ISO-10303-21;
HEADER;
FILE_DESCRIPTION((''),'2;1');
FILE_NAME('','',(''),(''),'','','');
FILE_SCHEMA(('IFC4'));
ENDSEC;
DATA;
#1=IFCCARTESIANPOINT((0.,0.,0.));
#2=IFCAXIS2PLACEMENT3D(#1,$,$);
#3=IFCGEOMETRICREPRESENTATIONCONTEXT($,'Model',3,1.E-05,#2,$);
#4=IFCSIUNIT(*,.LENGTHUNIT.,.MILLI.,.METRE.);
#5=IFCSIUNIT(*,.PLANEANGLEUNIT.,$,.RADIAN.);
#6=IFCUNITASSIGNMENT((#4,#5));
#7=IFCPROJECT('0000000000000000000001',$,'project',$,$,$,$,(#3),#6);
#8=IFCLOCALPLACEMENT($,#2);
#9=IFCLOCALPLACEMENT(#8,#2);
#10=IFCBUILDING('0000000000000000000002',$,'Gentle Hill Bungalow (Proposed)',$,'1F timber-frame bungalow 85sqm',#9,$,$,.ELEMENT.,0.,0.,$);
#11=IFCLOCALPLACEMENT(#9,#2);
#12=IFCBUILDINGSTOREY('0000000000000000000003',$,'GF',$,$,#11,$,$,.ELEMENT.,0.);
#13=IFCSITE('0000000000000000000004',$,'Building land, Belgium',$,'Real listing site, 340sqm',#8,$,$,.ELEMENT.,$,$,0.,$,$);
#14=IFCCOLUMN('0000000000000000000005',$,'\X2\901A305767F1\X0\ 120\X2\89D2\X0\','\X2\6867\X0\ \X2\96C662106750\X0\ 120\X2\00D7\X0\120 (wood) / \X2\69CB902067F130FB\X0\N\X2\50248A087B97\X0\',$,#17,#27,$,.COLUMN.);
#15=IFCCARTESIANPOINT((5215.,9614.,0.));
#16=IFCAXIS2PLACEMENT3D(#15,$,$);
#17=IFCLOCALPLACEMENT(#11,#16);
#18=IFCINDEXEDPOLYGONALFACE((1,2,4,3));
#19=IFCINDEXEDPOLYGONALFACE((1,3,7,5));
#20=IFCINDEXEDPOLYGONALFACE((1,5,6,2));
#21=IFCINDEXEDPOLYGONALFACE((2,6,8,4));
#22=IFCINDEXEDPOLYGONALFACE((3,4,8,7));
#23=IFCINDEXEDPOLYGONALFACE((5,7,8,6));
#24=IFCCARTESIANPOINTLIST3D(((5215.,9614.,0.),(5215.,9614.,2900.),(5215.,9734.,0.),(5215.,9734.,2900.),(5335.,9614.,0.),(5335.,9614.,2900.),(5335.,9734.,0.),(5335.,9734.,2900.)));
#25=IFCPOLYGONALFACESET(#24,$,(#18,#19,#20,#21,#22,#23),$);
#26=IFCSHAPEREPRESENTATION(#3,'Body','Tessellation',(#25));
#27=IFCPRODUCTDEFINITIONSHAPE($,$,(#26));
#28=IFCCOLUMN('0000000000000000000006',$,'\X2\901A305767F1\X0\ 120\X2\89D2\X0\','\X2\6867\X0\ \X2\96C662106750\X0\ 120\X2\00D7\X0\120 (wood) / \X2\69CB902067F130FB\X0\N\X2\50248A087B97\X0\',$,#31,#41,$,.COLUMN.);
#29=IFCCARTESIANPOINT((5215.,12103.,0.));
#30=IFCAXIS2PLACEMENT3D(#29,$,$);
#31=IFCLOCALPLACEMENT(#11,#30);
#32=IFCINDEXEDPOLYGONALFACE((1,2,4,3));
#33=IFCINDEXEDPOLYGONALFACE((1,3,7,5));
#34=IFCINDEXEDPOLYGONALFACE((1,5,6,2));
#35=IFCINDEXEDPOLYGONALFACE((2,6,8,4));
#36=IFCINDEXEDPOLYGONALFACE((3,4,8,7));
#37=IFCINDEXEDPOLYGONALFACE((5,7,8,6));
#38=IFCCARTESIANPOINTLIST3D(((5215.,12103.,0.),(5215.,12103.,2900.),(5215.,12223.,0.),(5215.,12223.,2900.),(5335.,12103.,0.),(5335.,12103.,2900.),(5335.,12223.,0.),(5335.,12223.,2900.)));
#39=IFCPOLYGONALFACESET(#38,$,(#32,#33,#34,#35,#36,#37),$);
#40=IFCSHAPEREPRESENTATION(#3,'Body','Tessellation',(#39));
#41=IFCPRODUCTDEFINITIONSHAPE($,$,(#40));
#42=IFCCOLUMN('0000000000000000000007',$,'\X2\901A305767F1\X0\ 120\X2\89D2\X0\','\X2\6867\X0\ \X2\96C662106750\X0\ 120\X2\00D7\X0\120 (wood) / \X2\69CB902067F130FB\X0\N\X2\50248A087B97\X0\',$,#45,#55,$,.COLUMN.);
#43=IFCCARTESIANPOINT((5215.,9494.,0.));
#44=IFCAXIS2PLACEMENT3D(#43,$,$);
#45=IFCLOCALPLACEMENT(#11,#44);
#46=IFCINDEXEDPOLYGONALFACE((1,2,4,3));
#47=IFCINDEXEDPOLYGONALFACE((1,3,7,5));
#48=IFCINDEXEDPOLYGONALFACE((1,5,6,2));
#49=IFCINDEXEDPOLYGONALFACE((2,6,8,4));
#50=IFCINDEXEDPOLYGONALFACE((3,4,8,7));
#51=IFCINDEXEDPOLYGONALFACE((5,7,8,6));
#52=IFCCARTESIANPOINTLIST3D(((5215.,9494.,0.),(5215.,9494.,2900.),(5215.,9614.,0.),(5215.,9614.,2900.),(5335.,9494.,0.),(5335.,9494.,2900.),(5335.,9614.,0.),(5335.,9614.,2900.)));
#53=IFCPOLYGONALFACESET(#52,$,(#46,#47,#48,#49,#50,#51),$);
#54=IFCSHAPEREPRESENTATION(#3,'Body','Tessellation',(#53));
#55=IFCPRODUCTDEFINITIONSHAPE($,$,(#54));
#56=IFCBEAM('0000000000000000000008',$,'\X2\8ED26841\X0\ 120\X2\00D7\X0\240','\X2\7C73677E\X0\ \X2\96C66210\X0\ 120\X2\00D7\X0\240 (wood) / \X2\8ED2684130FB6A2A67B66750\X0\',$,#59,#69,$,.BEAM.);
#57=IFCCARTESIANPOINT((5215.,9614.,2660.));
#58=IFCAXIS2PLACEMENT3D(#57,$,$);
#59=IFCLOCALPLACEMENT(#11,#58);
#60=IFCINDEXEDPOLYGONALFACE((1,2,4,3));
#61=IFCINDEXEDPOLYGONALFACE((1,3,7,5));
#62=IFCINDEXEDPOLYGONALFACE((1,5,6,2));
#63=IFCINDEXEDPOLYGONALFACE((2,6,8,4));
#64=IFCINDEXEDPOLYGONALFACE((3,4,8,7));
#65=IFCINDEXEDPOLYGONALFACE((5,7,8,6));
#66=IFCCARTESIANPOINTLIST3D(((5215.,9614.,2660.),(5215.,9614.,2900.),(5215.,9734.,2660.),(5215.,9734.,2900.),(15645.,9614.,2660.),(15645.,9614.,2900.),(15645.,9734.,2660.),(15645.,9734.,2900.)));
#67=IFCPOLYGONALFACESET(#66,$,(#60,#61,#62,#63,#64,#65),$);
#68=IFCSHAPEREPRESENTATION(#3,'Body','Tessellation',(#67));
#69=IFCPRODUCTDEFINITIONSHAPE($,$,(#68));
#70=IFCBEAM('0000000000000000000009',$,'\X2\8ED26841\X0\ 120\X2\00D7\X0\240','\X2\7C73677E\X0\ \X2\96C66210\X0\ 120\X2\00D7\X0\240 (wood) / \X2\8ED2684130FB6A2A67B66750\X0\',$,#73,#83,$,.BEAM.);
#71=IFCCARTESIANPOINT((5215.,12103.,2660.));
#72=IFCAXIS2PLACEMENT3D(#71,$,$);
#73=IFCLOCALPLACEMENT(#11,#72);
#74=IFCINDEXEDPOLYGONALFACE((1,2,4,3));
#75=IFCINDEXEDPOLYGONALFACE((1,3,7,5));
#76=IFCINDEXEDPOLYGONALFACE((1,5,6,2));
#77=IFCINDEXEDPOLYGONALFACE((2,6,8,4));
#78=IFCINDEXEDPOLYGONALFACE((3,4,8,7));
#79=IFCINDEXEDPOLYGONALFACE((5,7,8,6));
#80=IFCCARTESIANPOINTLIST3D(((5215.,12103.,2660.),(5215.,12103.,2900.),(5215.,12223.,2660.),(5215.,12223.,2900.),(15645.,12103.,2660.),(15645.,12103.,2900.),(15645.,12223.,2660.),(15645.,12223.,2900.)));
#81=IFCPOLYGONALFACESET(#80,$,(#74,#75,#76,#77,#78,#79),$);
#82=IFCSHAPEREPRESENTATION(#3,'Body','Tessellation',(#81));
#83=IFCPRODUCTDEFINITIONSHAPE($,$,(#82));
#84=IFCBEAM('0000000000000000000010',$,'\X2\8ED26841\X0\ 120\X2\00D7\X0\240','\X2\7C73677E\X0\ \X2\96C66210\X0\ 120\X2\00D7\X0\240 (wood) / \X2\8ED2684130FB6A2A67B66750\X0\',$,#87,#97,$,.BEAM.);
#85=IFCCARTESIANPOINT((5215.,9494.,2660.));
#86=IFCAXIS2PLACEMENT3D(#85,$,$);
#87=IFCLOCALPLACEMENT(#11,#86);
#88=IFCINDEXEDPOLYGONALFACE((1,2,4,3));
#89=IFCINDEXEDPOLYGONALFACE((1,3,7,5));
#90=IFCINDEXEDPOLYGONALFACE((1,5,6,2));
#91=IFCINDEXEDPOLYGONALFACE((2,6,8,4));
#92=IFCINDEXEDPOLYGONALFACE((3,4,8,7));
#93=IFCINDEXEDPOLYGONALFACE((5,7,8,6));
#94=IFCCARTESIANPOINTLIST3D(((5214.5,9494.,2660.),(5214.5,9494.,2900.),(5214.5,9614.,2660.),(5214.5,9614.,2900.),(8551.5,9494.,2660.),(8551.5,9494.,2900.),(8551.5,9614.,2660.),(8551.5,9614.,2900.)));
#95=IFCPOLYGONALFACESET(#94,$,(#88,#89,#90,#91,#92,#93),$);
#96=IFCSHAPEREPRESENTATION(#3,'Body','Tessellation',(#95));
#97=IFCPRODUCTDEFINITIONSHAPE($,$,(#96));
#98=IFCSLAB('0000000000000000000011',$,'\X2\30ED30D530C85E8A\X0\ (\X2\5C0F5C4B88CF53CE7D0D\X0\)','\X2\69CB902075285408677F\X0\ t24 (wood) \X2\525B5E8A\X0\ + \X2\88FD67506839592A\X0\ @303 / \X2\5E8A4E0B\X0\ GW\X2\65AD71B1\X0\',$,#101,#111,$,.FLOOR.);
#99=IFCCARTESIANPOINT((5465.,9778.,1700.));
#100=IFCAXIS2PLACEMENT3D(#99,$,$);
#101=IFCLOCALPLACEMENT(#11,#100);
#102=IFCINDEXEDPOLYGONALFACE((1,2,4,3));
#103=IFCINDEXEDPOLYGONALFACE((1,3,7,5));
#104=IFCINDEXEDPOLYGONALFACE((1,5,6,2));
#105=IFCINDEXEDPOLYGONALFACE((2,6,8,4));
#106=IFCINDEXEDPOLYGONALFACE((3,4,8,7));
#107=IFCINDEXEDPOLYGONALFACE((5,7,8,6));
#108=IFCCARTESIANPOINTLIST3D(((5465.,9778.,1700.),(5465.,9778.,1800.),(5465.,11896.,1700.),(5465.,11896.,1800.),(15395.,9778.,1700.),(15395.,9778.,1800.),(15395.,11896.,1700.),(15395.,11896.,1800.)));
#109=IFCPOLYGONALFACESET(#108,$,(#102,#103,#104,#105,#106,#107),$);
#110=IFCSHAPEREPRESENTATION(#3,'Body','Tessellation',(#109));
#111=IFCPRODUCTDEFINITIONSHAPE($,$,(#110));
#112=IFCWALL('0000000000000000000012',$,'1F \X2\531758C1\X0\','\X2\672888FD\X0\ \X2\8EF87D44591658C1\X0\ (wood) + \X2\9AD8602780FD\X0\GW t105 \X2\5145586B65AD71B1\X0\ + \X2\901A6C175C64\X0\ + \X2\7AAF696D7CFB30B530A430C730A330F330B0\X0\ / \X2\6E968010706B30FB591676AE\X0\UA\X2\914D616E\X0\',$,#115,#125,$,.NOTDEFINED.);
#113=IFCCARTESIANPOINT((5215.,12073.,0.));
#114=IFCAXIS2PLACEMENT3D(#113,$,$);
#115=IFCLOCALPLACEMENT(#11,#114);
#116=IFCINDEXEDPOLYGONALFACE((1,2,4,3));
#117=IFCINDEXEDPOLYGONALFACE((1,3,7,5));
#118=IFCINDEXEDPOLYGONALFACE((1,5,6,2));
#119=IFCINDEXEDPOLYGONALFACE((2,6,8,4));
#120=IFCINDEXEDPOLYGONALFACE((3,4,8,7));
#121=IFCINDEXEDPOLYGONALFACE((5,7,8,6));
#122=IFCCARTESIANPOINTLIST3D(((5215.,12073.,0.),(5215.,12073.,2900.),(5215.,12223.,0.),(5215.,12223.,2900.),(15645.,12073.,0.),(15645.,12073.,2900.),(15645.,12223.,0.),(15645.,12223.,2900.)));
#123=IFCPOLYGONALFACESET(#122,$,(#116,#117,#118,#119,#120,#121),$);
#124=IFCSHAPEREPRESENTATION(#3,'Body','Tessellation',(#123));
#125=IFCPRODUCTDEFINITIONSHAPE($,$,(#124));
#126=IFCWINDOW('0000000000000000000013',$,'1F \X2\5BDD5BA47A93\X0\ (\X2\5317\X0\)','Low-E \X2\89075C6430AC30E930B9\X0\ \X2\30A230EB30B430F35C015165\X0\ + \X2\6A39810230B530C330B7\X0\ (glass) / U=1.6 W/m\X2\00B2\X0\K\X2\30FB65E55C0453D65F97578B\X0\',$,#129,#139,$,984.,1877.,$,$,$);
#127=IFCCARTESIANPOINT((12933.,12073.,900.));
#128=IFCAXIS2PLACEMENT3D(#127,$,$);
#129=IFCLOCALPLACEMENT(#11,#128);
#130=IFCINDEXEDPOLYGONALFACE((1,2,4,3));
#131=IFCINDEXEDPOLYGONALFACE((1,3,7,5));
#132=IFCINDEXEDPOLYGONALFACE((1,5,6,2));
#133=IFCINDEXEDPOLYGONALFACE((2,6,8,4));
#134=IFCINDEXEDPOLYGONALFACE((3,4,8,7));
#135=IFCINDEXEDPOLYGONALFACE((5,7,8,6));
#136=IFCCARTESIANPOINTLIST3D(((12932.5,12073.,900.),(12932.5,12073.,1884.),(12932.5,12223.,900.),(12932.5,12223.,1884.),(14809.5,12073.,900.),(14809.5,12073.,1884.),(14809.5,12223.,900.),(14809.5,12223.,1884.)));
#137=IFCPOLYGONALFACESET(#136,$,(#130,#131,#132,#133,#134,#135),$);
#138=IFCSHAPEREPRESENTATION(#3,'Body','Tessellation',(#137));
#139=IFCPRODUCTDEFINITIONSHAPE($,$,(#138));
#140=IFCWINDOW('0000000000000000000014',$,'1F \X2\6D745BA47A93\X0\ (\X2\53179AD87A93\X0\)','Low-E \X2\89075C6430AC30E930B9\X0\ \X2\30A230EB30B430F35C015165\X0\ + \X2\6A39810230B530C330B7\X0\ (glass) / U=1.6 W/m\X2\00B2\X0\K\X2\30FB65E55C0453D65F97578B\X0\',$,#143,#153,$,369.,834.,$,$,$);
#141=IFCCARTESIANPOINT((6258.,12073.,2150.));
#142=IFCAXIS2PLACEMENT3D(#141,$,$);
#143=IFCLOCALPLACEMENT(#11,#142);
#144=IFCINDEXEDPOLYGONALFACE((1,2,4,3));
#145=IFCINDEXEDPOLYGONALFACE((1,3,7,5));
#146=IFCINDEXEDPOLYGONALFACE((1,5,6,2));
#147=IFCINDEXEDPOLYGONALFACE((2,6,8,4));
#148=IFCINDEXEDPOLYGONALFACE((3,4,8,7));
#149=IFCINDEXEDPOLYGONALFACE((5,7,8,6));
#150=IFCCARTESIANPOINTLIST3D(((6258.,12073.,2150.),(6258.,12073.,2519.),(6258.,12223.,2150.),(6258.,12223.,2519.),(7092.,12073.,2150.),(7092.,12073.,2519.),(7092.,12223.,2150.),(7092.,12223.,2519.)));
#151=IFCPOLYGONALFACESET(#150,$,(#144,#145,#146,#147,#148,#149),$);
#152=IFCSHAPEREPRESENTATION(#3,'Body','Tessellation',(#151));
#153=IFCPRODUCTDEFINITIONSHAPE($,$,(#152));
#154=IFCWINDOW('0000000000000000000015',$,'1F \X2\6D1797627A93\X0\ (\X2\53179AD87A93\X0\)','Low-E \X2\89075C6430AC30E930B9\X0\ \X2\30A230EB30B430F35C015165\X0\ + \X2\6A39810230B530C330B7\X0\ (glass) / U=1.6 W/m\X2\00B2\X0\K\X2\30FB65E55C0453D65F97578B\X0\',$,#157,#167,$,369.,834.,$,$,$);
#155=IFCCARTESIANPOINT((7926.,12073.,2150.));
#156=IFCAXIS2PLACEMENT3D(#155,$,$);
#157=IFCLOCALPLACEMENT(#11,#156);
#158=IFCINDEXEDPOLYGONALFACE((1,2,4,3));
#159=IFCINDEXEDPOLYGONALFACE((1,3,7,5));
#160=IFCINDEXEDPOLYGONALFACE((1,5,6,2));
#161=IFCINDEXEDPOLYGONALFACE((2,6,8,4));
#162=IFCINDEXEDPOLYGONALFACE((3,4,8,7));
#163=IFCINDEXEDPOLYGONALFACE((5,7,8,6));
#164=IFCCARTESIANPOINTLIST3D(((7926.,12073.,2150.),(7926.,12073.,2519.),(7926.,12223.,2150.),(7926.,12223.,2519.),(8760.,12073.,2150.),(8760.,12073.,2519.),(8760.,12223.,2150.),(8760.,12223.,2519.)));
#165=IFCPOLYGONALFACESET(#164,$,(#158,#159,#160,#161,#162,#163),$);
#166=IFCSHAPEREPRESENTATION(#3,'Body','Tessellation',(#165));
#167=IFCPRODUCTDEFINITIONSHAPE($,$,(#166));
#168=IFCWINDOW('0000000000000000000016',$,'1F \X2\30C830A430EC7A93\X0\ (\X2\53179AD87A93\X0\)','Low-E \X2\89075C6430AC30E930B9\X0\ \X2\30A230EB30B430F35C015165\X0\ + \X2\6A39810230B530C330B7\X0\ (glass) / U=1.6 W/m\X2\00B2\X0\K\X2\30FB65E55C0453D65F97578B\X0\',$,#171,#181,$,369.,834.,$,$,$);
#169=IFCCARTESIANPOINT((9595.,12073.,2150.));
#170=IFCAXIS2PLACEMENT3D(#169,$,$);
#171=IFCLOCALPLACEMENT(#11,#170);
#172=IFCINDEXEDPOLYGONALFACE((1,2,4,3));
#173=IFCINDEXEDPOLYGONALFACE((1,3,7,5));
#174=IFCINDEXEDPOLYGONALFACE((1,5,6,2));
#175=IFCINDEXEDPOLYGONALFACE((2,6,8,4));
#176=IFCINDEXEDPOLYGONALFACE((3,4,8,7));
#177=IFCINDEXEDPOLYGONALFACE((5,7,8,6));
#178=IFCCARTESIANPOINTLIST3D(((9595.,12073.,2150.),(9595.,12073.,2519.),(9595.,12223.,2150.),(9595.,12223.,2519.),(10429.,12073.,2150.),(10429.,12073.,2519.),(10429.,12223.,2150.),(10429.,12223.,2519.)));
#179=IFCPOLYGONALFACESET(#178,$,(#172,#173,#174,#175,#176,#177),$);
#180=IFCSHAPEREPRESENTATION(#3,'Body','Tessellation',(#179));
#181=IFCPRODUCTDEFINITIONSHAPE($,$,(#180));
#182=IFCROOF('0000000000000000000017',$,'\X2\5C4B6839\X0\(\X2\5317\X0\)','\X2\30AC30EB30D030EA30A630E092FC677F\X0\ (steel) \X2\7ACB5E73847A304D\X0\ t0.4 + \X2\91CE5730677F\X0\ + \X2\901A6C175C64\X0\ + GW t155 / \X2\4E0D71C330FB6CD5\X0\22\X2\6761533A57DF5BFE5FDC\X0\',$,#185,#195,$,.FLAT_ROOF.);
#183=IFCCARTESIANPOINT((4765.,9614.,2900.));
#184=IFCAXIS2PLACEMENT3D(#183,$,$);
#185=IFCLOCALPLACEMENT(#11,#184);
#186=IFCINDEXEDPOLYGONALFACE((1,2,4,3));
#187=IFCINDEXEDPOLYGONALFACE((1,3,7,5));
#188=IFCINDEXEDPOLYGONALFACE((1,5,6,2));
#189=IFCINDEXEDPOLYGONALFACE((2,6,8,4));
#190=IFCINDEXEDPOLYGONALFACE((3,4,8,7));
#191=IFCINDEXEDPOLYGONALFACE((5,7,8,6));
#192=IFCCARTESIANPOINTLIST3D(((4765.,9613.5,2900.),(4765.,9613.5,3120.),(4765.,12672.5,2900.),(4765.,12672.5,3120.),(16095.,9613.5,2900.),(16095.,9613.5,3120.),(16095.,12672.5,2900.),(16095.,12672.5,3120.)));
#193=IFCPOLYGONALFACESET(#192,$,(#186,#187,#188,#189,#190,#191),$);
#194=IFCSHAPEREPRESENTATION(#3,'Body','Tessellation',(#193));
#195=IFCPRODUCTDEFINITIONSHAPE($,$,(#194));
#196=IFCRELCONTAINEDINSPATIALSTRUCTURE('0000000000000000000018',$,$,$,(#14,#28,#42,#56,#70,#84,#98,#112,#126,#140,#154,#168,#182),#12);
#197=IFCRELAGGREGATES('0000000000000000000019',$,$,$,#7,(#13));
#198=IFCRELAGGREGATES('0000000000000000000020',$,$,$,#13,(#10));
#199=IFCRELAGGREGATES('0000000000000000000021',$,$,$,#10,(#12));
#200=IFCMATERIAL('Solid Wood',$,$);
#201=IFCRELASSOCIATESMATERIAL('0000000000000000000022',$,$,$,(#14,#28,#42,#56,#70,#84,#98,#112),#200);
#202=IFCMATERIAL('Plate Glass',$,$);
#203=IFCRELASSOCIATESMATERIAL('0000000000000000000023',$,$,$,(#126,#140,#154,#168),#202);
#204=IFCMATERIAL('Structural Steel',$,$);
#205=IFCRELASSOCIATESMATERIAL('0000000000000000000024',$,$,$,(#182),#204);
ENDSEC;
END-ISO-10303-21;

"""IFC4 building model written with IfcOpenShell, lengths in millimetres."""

from ifc_helpers import new_model, si_unit, frame, frame_2d, origin, place, context, project, spatial, rectangle, extrude, material, element, fill, save


model = new_model("IFC4")

# Units and contexts
model_context = context("Model", 3, precision=1e-05, world=origin())
ifc_project = project(units=[si_unit("LENGTHUNIT", "METRE", prefix="MILLI"), si_unit("PLANEANGLEUNIT", "RADIAN")], contexts=[model_context])

# Site, building, storey
site_placement = place(None, origin())
site = spatial("IfcSite", under=ifc_project, at=site_placement, Name="Building land, Belgium", ObjectType="Real listing site, 340sqm", CompositionType="ELEMENT", RefElevation=0.0)
building_placement = place(site_placement, origin())
building = spatial("IfcBuilding", under=site, at=building_placement, Name="Gentle Hill Bungalow (Proposed)", ObjectType="1F timber-frame bungalow 85sqm", CompositionType="ELEMENT", ElevationOfRefHeight=0.0, ElevationOfTerrain=0.0)
storey_placement = place(building_placement, origin())
storey = spatial("IfcBuildingStorey", under=building, at=storey_placement, Name="GF", CompositionType="ELEMENT", Elevation=0.0)

# Columns
ifc_material_1 = material(Name="Solid Wood")
column_1_placement = place(storey_placement, frame((5215.0, 9614.0, 0.0)))
element("IfcColumn", 1, at=column_1_placement, inside=storey, material=ifc_material_1, Name="通し柱 120角", Description="桧 集成材 120×120 (wood) / 構造柱・N値計算", PredefinedType="COLUMN", context=model_context, shape_type="SweptSolid", body=[
    extrude(rectangle(XDim=120.0, YDim=120.0, at=frame_2d((60.0, 60.0))), frame((5215.0, 9614.0, 0.0)), (0.0, 0.0, 1.0), 2900.0),
])
column_2_placement = place(storey_placement, frame((5215.0, 12103.0, 0.0)))
element("IfcColumn", 2, at=column_2_placement, inside=storey, material=ifc_material_1, Name="通し柱 120角", Description="桧 集成材 120×120 (wood) / 構造柱・N値計算", PredefinedType="COLUMN", context=model_context, shape_type="SweptSolid", body=[
    extrude(rectangle(XDim=120.0, YDim=120.0, at=frame_2d((60.0, 60.0))), frame((5215.0, 12103.0, 0.0)), (0.0, 0.0, 1.0), 2900.0),
])
column_3_placement = place(storey_placement, frame((5215.0, 9494.0, 0.0)))
element("IfcColumn", 3, at=column_3_placement, inside=storey, material=ifc_material_1, Name="通し柱 120角", Description="桧 集成材 120×120 (wood) / 構造柱・N値計算", PredefinedType="COLUMN", context=model_context, shape_type="SweptSolid", body=[
    extrude(rectangle(XDim=120.0, YDim=120.0, at=frame_2d((60.0, 60.0))), frame((5215.0, 9494.0, 0.0)), (0.0, 0.0, 1.0), 2900.0),
])

# Beams
beam_1_placement = place(storey_placement, frame((5215.0, 9614.0, 2660.0)))
element("IfcBeam", 4, at=beam_1_placement, inside=storey, material=ifc_material_1, Name="軒桁 120×240", Description="米松 集成 120×240 (wood) / 軒桁・横架材", PredefinedType="BEAM", context=model_context, shape_type="SweptSolid", body=[
    extrude(rectangle(XDim=10430.0, YDim=120.0, at=frame_2d((5215.0, 60.0))), frame((5215.0, 9614.0, 2660.0)), (0.0, 0.0, 1.0), 240.0),
])
beam_2_placement = place(storey_placement, frame((5215.0, 12103.0, 2660.0)))
element("IfcBeam", 5, at=beam_2_placement, inside=storey, material=ifc_material_1, Name="軒桁 120×240", Description="米松 集成 120×240 (wood) / 軒桁・横架材", PredefinedType="BEAM", context=model_context, shape_type="SweptSolid", body=[
    extrude(rectangle(XDim=10430.0, YDim=120.0, at=frame_2d((5215.0, 60.0))), frame((5215.0, 12103.0, 2660.0)), (0.0, 0.0, 1.0), 240.0),
])
beam_3_placement = place(storey_placement, frame((5215.0, 9494.0, 2660.0)))
element("IfcBeam", 6, at=beam_3_placement, inside=storey, material=ifc_material_1, Name="軒桁 120×240", Description="米松 集成 120×240 (wood) / 軒桁・横架材", PredefinedType="BEAM", context=model_context, shape_type="SweptSolid", body=[
    extrude(rectangle(XDim=3337.0, YDim=120.0, at=frame_2d((1668.0, 60.0))), frame((5215.0, 9494.0, 2660.0)), (0.0, 0.0, 1.0), 240.0),
])

# Slab
slab_1_placement = place(storey_placement, frame((5465.0, 9778.0, 1700.0)))
element("IfcSlab", 7, at=slab_1_placement, inside=storey, material=ifc_material_1, Name="ロフト床 (小屋裏収納)", Description="構造用合板 t24 (wood) 剛床 + 製材根太 @303 / 床下 GW断熱", PredefinedType="FLOOR", context=model_context, shape_type="SweptSolid", body=[
    extrude(rectangle(XDim=9930.0, YDim=2118.0, at=frame_2d((4965.0, 1059.0))), frame((5465.0, 9778.0, 1700.0)), (0.0, 0.0, 1.0), 100.0),
])

# Wall, openings, windows
wall_1_placement = place(storey_placement, frame((5215.0, 12073.0, 0.0)))
wall_1 = element("IfcWall", 8, at=wall_1_placement, inside=storey, material=ifc_material_1, Name="1F 北壁", Description="木製 軸組外壁 (wood) + 高性能GW t105 充填断熱 + 通気層 + 窯業系サイディング / 準耐火・外皮UA配慮", PredefinedType="NOTDEFINED", context=model_context, shape_type="SweptSolid", body=[
    extrude(rectangle(XDim=10430.0, YDim=150.0, at=frame_2d((5215.0, 75.0))), frame((5215.0, 12073.0, 0.0)), (0.0, 0.0, 1.0), 2900.0),
])
opening_1_placement = place(storey_placement, frame((12933.0, 12073.0, 900.0)))
opening_1 = element("IfcOpeningElement", 9, at=opening_1_placement, cuts=wall_1, PredefinedType="NOTDEFINED", context=model_context, shape_type="SweptSolid", body=[
    extrude(rectangle(XDim=1877.0, YDim=150.0, at=frame_2d((938.0, 75.0))), frame((12933.0, 12073.0, 900.0)), (0.0, 0.0, 1.0), 984.0),
])
opening_2_placement = place(storey_placement, frame((6258.0, 12073.0, 2150.0)))
opening_2 = element("IfcOpeningElement", 10, at=opening_2_placement, cuts=wall_1, PredefinedType="NOTDEFINED", context=model_context, shape_type="SweptSolid", body=[
    extrude(rectangle(XDim=834.0, YDim=150.0, at=frame_2d((417.0, 75.0))), frame((6258.0, 12073.0, 2150.0)), (0.0, 0.0, 1.0), 369.0),
])
opening_3_placement = place(storey_placement, frame((7926.0, 12073.0, 2150.0)))
opening_3 = element("IfcOpeningElement", 11, at=opening_3_placement, cuts=wall_1, PredefinedType="NOTDEFINED", context=model_context, shape_type="SweptSolid", body=[
    extrude(rectangle(XDim=834.0, YDim=150.0, at=frame_2d((417.0, 75.0))), frame((7926.0, 12073.0, 2150.0)), (0.0, 0.0, 1.0), 369.0),
])
opening_4_placement = place(storey_placement, frame((9595.0, 12073.0, 2150.0)))
opening_4 = element("IfcOpeningElement", 12, at=opening_4_placement, cuts=wall_1, PredefinedType="NOTDEFINED", context=model_context, shape_type="SweptSolid", body=[
    extrude(rectangle(XDim=834.0, YDim=150.0, at=frame_2d((417.0, 75.0))), frame((9595.0, 12073.0, 2150.0)), (0.0, 0.0, 1.0), 369.0),
])
ifc_material_2 = material(Name="Plate Glass")
window_1_placement = place(storey_placement, frame((12933.0, 12073.0, 900.0)))
window_1 = element("IfcWindow", 13, at=window_1_placement, inside=storey, material=ifc_material_2, Name="1F 寝室窓 (北)", Description="Low-E 複層ガラス アルゴン封入 + 樹脂サッシ (glass) / U=1.6 W/m²K・日射取得型", OverallHeight=984.0, OverallWidth=1877.0, context=model_context, shape_type="SweptSolid", body=[
    extrude(rectangle(XDim=1877.0, YDim=150.0, at=frame_2d((938.0, 75.0))), frame((12933.0, 12073.0, 900.0)), (0.0, 0.0, 1.0), 984.0),
])
fill(opening_1, window_1)
window_2_placement = place(storey_placement, frame((6258.0, 12073.0, 2150.0)))
window_2 = element("IfcWindow", 14, at=window_2_placement, inside=storey, material=ifc_material_2, Name="1F 浴室窓 (北高窓)", Description="Low-E 複層ガラス アルゴン封入 + 樹脂サッシ (glass) / U=1.6 W/m²K・日射取得型", OverallHeight=369.0, OverallWidth=834.0, context=model_context, shape_type="SweptSolid", body=[
    extrude(rectangle(XDim=834.0, YDim=150.0, at=frame_2d((417.0, 75.0))), frame((6258.0, 12073.0, 2150.0)), (0.0, 0.0, 1.0), 369.0),
])
fill(opening_2, window_2)
window_3_placement = place(storey_placement, frame((7926.0, 12073.0, 2150.0)))
window_3 = element("IfcWindow", 15, at=window_3_placement, inside=storey, material=ifc_material_2, Name="1F 洗面窓 (北高窓)", Description="Low-E 複層ガラス アルゴン封入 + 樹脂サッシ (glass) / U=1.6 W/m²K・日射取得型", OverallHeight=369.0, OverallWidth=834.0, context=model_context, shape_type="SweptSolid", body=[
    extrude(rectangle(XDim=834.0, YDim=150.0, at=frame_2d((417.0, 75.0))), frame((7926.0, 12073.0, 2150.0)), (0.0, 0.0, 1.0), 369.0),
])
fill(opening_3, window_3)
window_4_placement = place(storey_placement, frame((9595.0, 12073.0, 2150.0)))
window_4 = element("IfcWindow", 16, at=window_4_placement, inside=storey, material=ifc_material_2, Name="1F トイレ窓 (北高窓)", Description="Low-E 複層ガラス アルゴン封入 + 樹脂サッシ (glass) / U=1.6 W/m²K・日射取得型", OverallHeight=369.0, OverallWidth=834.0, context=model_context, shape_type="SweptSolid", body=[
    extrude(rectangle(XDim=834.0, YDim=150.0, at=frame_2d((417.0, 75.0))), frame((9595.0, 12073.0, 2150.0)), (0.0, 0.0, 1.0), 369.0),
])
fill(opening_4, window_4)

# Roof
ifc_material_3 = material(Name="Structural Steel")
roof_placement = place(storey_placement, frame((4765.0, 9614.0, 2900.0)))
element("IfcRoof", 17, at=roof_placement, inside=storey, material=ifc_material_3, Name="屋根(北)", Description="ガルバリウム鋼板 (steel) 立平葺き t0.4 + 野地板 + 通気層 + GW t155 / 不燃・法22条区域対応", PredefinedType="FLAT_ROOF", context=model_context, shape_type="SweptSolid", body=[
    extrude(rectangle(XDim=11330.0, YDim=3059.0, at=frame_2d((5665.0, 1529.0))), frame((4765.0, 9614.0, 2900.0)), (0.0, 0.0, 1.0), 220.0),
])

save(model, "model.ifc")
